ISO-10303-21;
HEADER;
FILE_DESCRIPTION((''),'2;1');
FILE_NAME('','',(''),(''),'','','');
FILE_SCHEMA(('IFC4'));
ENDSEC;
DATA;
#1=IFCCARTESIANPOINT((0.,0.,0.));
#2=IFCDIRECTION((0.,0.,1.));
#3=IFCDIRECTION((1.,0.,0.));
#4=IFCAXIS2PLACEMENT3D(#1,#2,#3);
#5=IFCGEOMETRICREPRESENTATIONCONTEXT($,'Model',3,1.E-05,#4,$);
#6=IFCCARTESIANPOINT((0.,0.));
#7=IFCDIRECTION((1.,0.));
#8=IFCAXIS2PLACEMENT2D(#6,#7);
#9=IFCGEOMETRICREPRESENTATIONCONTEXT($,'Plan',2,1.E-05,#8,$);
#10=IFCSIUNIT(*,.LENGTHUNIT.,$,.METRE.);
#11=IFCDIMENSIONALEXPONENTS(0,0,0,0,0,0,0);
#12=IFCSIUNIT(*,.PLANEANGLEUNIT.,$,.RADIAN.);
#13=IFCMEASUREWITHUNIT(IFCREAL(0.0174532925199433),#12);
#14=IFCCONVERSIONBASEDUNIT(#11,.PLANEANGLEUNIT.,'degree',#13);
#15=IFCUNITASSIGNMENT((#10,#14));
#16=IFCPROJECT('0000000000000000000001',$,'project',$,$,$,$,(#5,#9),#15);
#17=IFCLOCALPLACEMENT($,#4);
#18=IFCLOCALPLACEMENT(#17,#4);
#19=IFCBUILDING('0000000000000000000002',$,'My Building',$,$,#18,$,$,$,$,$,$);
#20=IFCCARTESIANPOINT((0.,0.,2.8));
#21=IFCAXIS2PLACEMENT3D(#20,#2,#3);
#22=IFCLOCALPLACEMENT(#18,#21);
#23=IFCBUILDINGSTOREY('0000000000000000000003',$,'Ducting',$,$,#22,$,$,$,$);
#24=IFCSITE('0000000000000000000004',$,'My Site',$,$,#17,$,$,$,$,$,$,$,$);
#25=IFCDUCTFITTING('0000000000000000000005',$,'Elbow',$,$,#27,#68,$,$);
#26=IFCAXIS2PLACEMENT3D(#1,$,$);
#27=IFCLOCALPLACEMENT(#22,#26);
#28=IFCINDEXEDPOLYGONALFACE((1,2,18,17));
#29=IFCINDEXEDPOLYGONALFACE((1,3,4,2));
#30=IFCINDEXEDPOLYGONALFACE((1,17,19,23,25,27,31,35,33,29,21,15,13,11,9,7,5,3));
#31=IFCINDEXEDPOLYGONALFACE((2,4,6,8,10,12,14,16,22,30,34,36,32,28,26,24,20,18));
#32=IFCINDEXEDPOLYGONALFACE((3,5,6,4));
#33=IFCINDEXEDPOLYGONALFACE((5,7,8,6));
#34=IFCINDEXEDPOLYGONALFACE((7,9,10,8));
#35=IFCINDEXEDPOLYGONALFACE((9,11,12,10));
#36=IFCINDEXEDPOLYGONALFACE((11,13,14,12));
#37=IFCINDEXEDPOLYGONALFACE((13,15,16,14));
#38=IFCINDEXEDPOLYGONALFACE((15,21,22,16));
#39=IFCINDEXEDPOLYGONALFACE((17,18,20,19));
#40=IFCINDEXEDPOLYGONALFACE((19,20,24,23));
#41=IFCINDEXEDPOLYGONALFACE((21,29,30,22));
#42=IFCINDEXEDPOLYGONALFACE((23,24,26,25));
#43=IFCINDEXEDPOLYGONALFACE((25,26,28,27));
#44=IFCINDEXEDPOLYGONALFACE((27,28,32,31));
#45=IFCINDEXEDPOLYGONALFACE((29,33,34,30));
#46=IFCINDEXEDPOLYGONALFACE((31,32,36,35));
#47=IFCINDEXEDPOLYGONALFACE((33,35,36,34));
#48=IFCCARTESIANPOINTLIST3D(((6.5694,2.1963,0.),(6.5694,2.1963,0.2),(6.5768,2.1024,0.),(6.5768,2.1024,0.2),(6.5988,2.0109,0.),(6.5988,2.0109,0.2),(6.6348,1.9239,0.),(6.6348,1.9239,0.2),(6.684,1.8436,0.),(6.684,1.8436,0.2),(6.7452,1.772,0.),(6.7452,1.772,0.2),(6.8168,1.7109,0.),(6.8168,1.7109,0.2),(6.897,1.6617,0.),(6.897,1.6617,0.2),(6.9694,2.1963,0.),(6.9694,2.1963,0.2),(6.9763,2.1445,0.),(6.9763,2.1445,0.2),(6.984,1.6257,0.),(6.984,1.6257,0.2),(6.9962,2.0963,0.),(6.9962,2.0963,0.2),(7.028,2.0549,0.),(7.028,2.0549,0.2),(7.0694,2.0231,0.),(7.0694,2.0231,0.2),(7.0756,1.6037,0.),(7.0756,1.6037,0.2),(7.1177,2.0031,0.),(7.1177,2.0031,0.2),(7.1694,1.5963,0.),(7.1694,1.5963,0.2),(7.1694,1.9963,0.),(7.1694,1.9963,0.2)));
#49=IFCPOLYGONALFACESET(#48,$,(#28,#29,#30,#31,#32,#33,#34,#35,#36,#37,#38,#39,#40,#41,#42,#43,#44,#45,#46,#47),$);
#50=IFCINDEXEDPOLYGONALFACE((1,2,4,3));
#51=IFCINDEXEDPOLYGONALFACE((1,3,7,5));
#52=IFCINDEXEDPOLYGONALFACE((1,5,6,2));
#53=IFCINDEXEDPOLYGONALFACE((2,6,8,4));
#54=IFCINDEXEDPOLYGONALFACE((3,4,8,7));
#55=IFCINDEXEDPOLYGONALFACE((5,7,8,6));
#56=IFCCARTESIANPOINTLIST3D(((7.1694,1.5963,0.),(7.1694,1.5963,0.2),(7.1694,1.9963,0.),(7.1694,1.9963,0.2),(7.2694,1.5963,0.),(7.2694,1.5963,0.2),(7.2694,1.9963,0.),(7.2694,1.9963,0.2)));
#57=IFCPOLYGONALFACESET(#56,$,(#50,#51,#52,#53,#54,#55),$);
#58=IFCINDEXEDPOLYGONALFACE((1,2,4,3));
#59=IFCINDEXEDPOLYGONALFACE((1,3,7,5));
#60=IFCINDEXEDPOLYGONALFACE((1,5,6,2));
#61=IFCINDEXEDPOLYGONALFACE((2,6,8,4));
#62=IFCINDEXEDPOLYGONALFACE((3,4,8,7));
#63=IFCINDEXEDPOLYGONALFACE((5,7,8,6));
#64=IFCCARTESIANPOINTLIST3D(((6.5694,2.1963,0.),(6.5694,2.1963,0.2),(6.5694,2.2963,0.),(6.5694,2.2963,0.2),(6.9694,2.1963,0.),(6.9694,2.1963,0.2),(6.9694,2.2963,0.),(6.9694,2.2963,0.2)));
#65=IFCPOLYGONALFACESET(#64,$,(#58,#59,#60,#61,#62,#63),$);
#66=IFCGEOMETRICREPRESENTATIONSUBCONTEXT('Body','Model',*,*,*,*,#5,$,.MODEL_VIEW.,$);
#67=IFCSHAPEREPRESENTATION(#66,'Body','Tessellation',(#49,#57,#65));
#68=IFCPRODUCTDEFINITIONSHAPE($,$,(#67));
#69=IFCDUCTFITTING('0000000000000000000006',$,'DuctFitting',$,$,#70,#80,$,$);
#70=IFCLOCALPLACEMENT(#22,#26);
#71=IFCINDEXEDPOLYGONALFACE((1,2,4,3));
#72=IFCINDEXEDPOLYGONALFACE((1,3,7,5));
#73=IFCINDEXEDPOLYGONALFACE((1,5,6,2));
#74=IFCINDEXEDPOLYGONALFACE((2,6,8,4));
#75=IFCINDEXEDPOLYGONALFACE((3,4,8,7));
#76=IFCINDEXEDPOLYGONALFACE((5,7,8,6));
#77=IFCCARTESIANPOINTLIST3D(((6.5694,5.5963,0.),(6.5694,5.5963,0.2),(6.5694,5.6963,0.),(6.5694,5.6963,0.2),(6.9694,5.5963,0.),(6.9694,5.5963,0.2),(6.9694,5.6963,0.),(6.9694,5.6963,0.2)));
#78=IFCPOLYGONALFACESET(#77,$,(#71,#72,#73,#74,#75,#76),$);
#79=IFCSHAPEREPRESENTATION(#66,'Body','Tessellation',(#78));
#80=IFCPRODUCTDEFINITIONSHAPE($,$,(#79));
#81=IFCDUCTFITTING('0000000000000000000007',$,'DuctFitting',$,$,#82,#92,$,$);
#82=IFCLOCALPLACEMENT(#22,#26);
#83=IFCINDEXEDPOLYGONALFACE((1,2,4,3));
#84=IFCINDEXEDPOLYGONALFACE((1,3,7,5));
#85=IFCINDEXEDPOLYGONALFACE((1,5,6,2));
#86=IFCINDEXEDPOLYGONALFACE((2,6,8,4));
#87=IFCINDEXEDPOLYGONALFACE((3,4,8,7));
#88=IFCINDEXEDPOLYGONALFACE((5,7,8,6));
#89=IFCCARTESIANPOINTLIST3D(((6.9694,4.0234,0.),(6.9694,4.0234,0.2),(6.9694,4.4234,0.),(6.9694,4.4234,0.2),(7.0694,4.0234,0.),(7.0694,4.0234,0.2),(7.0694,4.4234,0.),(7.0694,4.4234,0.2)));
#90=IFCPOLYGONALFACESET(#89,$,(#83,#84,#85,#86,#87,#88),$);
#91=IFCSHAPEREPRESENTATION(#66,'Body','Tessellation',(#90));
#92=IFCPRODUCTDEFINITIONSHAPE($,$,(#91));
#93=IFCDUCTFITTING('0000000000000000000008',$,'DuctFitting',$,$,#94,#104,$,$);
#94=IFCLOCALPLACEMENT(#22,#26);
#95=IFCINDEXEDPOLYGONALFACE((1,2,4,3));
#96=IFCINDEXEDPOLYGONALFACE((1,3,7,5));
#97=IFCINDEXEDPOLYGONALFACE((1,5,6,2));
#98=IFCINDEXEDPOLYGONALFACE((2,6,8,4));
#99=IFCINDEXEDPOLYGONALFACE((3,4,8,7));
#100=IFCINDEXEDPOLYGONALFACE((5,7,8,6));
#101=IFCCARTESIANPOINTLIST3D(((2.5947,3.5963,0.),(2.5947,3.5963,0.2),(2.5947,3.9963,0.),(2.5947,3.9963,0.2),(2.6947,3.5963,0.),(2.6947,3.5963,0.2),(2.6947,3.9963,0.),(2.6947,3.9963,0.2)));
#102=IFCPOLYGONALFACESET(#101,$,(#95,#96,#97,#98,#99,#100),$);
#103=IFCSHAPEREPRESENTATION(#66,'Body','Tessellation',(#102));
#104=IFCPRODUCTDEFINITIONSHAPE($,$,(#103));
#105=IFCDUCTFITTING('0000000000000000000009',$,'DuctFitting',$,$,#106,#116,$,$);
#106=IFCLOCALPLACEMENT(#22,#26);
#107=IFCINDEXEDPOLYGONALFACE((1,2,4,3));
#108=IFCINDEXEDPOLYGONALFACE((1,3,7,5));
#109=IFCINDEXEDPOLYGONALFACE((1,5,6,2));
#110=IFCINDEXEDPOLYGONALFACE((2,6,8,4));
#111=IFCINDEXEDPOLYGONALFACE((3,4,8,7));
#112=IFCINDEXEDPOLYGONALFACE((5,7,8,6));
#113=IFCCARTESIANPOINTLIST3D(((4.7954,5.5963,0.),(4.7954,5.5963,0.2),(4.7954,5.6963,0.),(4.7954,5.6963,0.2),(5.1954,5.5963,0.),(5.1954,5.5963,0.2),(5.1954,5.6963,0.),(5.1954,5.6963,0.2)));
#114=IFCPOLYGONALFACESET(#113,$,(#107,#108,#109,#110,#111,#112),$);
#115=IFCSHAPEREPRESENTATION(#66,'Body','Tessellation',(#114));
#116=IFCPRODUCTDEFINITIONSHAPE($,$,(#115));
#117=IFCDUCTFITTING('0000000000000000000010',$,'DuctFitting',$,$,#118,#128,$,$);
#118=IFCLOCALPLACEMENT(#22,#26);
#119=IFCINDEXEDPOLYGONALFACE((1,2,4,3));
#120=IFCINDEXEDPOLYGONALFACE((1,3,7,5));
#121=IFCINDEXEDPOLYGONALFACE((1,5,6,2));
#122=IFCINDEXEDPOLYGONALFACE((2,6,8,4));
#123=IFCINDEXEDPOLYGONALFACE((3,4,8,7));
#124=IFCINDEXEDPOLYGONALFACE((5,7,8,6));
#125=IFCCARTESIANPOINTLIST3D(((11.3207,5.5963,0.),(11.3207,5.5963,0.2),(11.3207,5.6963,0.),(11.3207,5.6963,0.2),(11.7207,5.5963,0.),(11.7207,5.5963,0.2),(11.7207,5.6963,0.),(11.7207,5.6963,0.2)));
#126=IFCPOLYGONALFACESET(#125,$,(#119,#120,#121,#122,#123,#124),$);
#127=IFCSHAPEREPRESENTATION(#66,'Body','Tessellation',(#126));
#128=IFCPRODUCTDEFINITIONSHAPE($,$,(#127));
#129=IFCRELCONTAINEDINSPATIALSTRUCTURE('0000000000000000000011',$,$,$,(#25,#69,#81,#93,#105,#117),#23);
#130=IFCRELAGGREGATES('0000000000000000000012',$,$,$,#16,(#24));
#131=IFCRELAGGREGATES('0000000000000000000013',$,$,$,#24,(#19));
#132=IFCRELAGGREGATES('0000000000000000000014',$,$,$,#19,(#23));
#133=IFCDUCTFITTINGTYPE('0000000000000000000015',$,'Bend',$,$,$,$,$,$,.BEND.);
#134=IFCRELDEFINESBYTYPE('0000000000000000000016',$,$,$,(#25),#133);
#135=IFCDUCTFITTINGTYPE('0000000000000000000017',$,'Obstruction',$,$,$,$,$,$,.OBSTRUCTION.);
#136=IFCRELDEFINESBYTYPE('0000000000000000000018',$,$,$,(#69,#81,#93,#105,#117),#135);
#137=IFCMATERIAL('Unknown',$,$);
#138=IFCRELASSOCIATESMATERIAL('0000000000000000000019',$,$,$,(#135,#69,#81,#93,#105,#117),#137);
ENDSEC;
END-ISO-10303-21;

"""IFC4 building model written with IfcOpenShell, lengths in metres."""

from ifc_helpers import new_model, entity, si_unit, converted_unit, frame, origin_with_axes, origin_2d_with_axis, place, context, subcontext, project, spatial, line, arc, indexed_curve, rectangle, outline, extrude, source, transform, mapped, material, material_profile, profile_set, profile_usage, type_object, type_shapes, element, save


model = new_model("IFC4")

# Units and contexts
model_context = context("Model", 3, precision=1e-05, world=origin_with_axes())
plan_context = context("Plan", 2, precision=1e-05, world=origin_2d_with_axis())
body_context = subcontext(model_context, "Body", "Model", "MODEL_VIEW")
ifc_project = project(units=[si_unit("LENGTHUNIT", "METRE"), converted_unit("PLANEANGLEUNIT", "degree", entity("IfcReal", 0.0174532925199433), si_unit("PLANEANGLEUNIT", "RADIAN"), dimensions=[0, 0, 0, 0, 0, 0, 0])], contexts=[model_context, plan_context])

# Site, building, storey
site_placement = place(None, origin_with_axes())
site = spatial("IfcSite", under=ifc_project, at=site_placement, Name="My Site")
building_placement = place(site_placement, origin_with_axes())
building = spatial("IfcBuilding", under=site, at=building_placement, Name="My Building")
storey_placement = place(building_placement, frame((0.0, 0.0, 2.8), z_axis=(0.0, 0.0, 1.0), x_axis=(1.0, 0.0, 0.0)))
storey = spatial("IfcBuildingStorey", under=building, at=storey_placement, Name="Ducting")

# Shared definitions
ifc_material = material(Name="Unknown")

# Duct fittings
duct_fitting_type_1 = type_object("IfcDuctFittingType", Name="Bend", PredefinedType="BEND")
shared_shape = source(origin_with_axes(), body_context, "Body", "SweptSolid", [
    extrude(outline(indexed_curve([(0.2, 0.0), (0.2586, 0.1414), (0.4, 0.2), (0.4, 0.6), (-0.0243, 0.4243), (-0.2, 0.0)], segments=[arc(1, 2, 3), line(3, 4), arc(4, 5, 6), line(6, 1)])), frame((0.0, -0.1, 0.1), z_axis=(0.0, -1.0, 0.0), x_axis=(1.0, 0.0, 0.0)), (0.0, 0.0, -1.0), 0.2),
    extrude(rectangle(XDim=0.4, YDim=0.2), origin_with_axes(), (0.0, 0.0, 1.0), 0.1),
    extrude(rectangle(XDim=0.4, YDim=0.2), frame((0.4, 0.0, 0.5), z_axis=(1.0, 0.0, 0.0), x_axis=(0.0, 0.0, 1.0)), (0.0, 0.0, 1.0), 0.1),
])
type_shapes(duct_fitting_type_1, [shared_shape])
for number, where, z_axis, x_axis, name in (
    (1, (7.2694, 1.7963, 0.1), (-1.0, 0.0, 0.0), (0.0, 1.0, 0.0), "Elbow"),
):
    element("IfcDuctFitting", number, at=place(storey_placement, frame(where, z_axis=z_axis, x_axis=x_axis)), inside=storey, type_object=duct_fitting_type_1, Name=name, context=body_context, shape_type="MappedRepresentation", body=[
        mapped(shared_shape, transform((0.0, 0.0, 0.0), x_axis=(1.0, 0.0, 0.0), y_axis=(0.0, 1.0, 0.0), z_axis=(0.0, 0.0, 1.0), scale=1.0)),
    ])
ifc_material_profile_1 = material_profile(ifc_material, rectangle(XDim=0.4, YDim=0.2))
ifc_profile_set_1 = profile_set([ifc_material_profile_1])
ifc_profile_usage_1 = profile_usage(ifc_profile_set_1, cardinal=8)
duct_fitting_type_2 = type_object("IfcDuctFittingType", Name="Obstruction", PredefinedType="OBSTRUCTION", material=ifc_profile_set_1)
duct_fitting_1_placement = place(storey_placement, frame((6.7694, 5.6963, 0.2), z_axis=(0.0, -1.0, 0.0), x_axis=(1.0, 0.0, 0.0)))
element("IfcDuctFitting", 2, at=duct_fitting_1_placement, inside=storey, type_object=duct_fitting_type_2, material=ifc_profile_usage_1, Name="DuctFitting", context=body_context, shape_type="SweptSolid", body=[
    extrude(rectangle(XDim=0.4, YDim=0.2), frame((0.0, -0.1, 0.0), z_axis=(0.0, 0.0, 1.0), x_axis=(1.0, 0.0, 0.0)), (0.0, 0.0, 1.0), 0.1),
])
ifc_profile_usage_2 = profile_usage(ifc_profile_set_1, cardinal=8)
duct_fitting_2_placement = place(storey_placement, frame((7.0694, 4.2234, 0.2), z_axis=(-1.0, 0.0, 0.0), x_axis=(0.0, -1.0, 0.0)))
element("IfcDuctFitting", 3, at=duct_fitting_2_placement, inside=storey, type_object=duct_fitting_type_2, material=ifc_profile_usage_2, Name="DuctFitting", context=body_context, shape_type="SweptSolid", body=[
    extrude(rectangle(XDim=0.4, YDim=0.2), frame((0.0, -0.1, 0.0), z_axis=(0.0, 0.0, 1.0), x_axis=(1.0, 0.0, 0.0)), (0.0, 0.0, 1.0), 0.1),
])
ifc_profile_usage_3 = profile_usage(ifc_profile_set_1, cardinal=8)
duct_fitting_3_placement = place(storey_placement, frame((2.5947, 3.7963, 0.2), z_axis=(1.0, 0.0, 0.0), x_axis=(0.0, 1.0, 0.0)))
element("IfcDuctFitting", 4, at=duct_fitting_3_placement, inside=storey, type_object=duct_fitting_type_2, material=ifc_profile_usage_3, Name="DuctFitting", context=body_context, shape_type="SweptSolid", body=[
    extrude(rectangle(XDim=0.4, YDim=0.2), frame((0.0, -0.1, 0.0), z_axis=(0.0, 0.0, 1.0), x_axis=(1.0, 0.0, 0.0)), (0.0, 0.0, 1.0), 0.1),
])
ifc_profile_usage_4 = profile_usage(ifc_profile_set_1, cardinal=8)
duct_fitting_4_placement = place(storey_placement, frame((4.9954, 5.5963, 0.2), z_axis=(0.0, 1.0, 0.0), x_axis=(-1.0, 0.0, 0.0)))
element("IfcDuctFitting", 5, at=duct_fitting_4_placement, inside=storey, type_object=duct_fitting_type_2, material=ifc_profile_usage_4, Name="DuctFitting", context=body_context, shape_type="SweptSolid", body=[
    extrude(rectangle(XDim=0.4, YDim=0.2), frame((0.0, -0.1, 0.0), z_axis=(0.0, 0.0, 1.0), x_axis=(1.0, 0.0, 0.0)), (0.0, 0.0, 1.0), 0.1),
])
ifc_profile_usage_5 = profile_usage(ifc_profile_set_1, cardinal=8)
duct_fitting_5_placement = place(storey_placement, frame((11.5207, 5.5963, 0.2), z_axis=(0.0, 1.0, 0.0), x_axis=(-1.0, 0.0, 0.0)))
element("IfcDuctFitting", 6, at=duct_fitting_5_placement, inside=storey, type_object=duct_fitting_type_2, material=ifc_profile_usage_5, Name="DuctFitting", context=body_context, shape_type="SweptSolid", body=[
    extrude(rectangle(XDim=0.4, YDim=0.2), frame((0.0, -0.1, 0.0), z_axis=(0.0, 0.0, 1.0), x_axis=(1.0, 0.0, 0.0)), (0.0, 0.0, 1.0), 0.1),
])

save(model, "model.ifc")
